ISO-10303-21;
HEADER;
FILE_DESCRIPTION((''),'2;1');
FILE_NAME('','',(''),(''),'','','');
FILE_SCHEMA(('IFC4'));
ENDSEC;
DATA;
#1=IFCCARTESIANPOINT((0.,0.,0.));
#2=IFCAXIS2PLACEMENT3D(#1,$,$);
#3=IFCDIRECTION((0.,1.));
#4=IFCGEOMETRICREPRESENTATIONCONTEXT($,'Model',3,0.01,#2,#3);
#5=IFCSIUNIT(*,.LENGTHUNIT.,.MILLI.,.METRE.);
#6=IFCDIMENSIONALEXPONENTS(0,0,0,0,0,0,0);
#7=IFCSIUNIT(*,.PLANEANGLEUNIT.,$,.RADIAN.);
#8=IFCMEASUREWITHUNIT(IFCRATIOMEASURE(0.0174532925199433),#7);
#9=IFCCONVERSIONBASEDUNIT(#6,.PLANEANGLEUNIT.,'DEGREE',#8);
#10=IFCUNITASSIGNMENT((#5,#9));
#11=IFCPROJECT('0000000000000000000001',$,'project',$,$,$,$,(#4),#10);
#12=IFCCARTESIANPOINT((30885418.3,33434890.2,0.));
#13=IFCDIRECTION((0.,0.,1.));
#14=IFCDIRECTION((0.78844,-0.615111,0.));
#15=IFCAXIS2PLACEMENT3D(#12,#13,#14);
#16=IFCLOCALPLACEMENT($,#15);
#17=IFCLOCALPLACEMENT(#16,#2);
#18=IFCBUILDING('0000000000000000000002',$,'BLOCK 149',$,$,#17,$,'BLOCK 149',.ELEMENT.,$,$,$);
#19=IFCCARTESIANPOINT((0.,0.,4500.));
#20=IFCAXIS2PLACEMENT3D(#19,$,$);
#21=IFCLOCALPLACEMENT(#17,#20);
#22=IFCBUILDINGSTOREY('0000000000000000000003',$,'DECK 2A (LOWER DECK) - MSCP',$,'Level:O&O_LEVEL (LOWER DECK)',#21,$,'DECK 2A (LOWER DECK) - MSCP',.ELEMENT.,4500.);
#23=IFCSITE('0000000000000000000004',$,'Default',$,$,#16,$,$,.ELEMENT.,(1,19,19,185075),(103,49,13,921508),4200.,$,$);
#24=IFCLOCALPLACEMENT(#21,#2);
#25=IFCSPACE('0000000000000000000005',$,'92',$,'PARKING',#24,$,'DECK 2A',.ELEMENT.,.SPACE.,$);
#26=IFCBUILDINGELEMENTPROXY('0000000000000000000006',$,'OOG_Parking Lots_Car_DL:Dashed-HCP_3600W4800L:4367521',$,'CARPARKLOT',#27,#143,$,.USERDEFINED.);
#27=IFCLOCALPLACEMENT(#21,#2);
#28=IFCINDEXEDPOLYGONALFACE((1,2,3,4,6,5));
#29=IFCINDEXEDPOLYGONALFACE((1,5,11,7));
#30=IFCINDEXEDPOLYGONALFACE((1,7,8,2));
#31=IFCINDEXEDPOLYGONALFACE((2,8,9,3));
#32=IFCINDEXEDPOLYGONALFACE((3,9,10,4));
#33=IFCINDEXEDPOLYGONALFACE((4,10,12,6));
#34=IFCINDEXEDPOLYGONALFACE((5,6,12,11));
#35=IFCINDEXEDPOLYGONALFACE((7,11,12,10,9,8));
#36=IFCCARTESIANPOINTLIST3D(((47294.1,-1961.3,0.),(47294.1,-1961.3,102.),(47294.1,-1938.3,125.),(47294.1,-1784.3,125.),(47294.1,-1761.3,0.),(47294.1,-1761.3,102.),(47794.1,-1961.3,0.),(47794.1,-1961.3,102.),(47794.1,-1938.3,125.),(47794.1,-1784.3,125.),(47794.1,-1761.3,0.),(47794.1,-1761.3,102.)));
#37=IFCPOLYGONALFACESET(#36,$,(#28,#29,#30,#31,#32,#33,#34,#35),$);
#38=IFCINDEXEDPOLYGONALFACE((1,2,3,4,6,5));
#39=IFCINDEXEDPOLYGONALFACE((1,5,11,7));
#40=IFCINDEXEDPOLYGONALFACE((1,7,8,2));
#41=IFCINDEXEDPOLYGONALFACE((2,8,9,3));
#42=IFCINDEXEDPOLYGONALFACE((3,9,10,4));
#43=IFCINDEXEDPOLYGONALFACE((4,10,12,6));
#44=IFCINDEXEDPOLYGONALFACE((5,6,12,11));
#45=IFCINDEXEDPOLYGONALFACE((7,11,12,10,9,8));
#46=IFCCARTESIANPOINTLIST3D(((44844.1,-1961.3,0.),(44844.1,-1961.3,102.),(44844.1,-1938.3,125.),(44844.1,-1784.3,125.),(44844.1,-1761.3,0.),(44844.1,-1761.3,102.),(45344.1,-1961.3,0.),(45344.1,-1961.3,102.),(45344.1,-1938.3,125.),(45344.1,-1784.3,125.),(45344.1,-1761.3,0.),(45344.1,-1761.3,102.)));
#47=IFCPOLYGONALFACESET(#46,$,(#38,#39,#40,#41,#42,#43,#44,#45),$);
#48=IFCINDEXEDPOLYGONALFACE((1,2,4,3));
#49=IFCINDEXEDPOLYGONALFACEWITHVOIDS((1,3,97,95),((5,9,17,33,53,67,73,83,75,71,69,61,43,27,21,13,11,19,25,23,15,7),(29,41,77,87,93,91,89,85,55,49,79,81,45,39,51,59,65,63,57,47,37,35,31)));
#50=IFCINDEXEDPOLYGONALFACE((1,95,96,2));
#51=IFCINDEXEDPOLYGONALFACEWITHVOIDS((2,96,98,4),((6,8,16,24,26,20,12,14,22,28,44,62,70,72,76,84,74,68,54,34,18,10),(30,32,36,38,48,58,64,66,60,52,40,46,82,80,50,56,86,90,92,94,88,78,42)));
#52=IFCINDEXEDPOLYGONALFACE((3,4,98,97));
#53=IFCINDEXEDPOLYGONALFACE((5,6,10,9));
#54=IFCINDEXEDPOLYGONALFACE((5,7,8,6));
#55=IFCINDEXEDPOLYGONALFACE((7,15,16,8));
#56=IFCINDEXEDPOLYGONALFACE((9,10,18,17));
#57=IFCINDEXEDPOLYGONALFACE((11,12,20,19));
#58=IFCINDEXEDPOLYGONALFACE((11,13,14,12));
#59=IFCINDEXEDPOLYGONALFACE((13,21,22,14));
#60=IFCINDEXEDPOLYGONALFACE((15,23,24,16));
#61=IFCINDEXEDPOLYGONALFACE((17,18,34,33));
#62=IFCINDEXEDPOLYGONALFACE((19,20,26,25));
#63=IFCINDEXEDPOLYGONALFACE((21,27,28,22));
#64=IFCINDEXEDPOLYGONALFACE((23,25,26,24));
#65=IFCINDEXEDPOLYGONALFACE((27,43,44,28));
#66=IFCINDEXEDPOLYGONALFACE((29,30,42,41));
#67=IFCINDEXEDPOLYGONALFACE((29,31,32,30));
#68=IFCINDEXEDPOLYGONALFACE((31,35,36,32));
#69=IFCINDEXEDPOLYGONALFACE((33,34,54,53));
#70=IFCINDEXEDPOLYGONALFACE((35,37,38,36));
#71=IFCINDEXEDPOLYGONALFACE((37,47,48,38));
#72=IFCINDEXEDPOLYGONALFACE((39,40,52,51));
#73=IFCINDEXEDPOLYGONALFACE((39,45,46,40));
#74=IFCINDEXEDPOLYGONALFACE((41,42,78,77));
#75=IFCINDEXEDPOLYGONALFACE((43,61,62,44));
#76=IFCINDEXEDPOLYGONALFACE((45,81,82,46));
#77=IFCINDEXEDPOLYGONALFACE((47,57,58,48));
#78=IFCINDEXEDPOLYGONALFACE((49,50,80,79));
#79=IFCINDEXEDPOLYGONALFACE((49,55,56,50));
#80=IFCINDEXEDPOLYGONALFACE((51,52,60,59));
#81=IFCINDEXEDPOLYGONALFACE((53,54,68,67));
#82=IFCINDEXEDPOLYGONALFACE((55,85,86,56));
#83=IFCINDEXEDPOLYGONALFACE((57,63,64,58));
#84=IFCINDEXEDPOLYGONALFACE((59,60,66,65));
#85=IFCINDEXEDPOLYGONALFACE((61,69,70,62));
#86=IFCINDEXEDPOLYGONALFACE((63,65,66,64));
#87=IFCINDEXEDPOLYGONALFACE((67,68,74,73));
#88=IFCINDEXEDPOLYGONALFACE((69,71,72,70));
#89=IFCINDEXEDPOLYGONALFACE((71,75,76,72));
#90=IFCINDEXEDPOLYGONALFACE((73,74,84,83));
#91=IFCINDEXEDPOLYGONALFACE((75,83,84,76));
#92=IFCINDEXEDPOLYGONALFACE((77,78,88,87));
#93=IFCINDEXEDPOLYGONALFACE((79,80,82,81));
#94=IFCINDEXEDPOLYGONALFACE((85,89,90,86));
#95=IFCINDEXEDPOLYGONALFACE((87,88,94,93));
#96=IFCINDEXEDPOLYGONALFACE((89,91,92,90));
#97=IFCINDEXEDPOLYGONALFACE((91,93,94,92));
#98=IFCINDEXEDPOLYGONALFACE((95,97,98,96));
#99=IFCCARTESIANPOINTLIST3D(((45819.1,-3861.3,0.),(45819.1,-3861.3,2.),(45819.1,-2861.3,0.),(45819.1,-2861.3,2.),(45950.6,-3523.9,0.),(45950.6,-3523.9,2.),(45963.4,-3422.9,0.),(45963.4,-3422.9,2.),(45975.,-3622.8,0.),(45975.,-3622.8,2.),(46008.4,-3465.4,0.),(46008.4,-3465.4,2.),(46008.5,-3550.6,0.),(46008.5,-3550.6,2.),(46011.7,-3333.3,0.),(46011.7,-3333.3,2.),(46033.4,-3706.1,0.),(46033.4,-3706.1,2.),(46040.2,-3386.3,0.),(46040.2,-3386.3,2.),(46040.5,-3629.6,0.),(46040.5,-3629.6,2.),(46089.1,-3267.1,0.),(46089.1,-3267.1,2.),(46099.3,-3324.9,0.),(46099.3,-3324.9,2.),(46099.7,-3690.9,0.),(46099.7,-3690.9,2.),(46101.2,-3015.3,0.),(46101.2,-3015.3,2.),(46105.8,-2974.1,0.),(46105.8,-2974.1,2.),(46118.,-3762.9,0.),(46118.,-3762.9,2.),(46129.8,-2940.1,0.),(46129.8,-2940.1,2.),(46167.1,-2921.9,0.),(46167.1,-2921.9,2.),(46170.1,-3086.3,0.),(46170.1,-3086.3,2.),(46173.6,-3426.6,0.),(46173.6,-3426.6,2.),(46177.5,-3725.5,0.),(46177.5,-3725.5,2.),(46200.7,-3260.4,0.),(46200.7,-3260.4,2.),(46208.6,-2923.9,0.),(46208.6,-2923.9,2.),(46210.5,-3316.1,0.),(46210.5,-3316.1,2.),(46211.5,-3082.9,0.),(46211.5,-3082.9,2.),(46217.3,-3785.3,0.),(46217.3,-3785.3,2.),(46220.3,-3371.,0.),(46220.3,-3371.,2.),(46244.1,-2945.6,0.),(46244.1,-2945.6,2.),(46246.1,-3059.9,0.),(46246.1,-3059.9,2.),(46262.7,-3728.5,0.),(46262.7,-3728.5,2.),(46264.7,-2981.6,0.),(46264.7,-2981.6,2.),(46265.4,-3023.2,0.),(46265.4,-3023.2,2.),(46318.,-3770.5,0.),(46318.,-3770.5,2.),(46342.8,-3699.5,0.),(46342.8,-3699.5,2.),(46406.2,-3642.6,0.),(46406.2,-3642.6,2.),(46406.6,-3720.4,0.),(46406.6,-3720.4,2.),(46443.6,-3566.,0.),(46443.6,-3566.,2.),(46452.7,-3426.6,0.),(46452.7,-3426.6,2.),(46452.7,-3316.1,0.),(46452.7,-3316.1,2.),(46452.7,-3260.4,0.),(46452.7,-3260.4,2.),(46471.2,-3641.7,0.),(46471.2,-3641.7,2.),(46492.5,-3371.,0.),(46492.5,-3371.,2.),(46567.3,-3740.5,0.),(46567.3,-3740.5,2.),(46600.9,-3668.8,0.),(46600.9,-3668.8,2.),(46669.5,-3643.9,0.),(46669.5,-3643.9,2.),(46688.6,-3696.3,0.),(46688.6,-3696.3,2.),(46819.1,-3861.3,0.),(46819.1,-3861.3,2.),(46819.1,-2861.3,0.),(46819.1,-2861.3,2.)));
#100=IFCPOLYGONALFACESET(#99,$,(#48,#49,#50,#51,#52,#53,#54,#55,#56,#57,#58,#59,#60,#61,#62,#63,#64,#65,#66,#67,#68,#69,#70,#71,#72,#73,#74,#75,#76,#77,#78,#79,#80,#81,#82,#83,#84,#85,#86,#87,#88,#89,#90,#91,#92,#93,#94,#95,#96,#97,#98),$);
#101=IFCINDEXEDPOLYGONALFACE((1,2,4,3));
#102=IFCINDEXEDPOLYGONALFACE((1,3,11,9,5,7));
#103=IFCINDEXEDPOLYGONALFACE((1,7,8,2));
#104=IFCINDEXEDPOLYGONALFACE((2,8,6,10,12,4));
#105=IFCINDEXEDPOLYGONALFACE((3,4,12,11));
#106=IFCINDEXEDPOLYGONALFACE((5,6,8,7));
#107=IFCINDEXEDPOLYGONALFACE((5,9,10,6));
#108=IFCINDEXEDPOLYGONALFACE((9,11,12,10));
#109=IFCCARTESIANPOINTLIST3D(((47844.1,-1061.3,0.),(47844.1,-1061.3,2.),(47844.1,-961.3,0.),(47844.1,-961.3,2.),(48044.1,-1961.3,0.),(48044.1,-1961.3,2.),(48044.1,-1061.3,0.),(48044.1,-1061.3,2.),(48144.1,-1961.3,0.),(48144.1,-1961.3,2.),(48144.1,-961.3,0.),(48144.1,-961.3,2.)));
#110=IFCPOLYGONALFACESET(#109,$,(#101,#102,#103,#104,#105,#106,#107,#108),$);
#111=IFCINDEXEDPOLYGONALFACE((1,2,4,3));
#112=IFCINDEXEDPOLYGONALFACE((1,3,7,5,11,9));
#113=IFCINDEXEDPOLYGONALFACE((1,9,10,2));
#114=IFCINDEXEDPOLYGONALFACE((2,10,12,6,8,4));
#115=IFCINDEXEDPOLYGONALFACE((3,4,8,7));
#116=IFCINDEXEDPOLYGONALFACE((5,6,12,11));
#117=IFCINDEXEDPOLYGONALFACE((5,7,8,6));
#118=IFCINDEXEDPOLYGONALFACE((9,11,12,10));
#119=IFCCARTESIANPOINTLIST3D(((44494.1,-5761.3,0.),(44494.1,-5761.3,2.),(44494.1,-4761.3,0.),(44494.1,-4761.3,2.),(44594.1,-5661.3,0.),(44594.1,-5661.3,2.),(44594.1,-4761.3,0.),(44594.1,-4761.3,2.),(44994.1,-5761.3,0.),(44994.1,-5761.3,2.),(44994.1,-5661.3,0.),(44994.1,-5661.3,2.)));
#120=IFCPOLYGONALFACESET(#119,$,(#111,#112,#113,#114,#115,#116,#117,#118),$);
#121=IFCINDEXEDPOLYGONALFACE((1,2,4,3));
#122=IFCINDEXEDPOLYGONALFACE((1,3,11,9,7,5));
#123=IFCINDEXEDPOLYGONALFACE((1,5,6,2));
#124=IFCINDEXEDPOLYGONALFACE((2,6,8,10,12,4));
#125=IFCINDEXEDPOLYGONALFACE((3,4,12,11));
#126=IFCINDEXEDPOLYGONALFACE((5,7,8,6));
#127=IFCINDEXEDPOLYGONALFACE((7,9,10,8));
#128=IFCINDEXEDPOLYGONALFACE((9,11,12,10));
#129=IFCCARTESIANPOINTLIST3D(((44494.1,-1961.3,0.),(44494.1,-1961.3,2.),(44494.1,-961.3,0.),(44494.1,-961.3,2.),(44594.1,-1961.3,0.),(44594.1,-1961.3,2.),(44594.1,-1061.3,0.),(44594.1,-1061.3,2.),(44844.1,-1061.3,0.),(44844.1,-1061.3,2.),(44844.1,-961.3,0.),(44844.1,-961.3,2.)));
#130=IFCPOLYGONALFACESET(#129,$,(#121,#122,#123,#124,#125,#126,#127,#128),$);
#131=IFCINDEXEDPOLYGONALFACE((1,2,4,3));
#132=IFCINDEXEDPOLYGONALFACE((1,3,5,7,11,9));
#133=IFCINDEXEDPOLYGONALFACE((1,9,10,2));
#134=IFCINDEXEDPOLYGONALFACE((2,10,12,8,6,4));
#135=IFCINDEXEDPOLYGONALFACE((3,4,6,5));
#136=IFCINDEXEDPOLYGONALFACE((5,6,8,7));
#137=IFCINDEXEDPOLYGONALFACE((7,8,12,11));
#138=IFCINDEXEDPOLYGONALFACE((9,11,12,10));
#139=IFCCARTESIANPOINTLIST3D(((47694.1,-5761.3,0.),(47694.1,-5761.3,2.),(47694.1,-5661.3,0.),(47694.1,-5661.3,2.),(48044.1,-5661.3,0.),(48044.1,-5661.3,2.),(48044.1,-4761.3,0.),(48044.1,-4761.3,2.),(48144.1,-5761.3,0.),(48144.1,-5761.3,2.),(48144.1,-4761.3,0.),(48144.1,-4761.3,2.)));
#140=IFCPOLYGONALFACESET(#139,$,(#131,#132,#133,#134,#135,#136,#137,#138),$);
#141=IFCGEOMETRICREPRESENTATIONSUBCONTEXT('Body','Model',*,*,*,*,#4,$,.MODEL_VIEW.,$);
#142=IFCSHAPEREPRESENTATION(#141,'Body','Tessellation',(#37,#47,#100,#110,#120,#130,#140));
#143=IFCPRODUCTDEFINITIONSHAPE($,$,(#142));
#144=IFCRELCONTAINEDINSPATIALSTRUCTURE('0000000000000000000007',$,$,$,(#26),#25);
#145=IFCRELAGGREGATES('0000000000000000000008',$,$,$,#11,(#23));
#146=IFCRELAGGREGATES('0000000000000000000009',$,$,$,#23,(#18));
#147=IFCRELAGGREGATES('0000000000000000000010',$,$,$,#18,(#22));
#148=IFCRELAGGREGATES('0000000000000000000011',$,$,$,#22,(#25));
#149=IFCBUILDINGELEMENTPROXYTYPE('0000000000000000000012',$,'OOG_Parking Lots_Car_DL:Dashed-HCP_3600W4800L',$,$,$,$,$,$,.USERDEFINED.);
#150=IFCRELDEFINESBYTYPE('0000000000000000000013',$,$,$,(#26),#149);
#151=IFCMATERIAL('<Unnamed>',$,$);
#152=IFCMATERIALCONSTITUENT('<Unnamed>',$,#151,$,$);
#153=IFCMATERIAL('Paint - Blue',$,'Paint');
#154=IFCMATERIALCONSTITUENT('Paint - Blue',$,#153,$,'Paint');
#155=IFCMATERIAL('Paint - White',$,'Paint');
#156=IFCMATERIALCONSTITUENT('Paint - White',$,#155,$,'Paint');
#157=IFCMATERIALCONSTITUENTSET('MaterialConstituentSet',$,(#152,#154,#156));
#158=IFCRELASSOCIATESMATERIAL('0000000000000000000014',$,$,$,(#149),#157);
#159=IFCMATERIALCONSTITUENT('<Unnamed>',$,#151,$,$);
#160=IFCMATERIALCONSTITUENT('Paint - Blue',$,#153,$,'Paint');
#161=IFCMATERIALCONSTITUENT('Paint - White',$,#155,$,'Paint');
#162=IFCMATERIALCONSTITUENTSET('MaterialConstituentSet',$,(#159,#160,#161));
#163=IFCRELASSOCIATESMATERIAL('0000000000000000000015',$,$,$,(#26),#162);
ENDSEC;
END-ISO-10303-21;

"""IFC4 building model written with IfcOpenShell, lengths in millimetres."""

from ifc_helpers import new_model, entity, si_unit, converted_unit, direction, frame, origin, place, context, subcontext, project, spatial, indexed_curve, outline, extrude, source, transform, mapped, material, constituent, constituent_set, type_object, type_shapes, element, save


model = new_model("IFC4")

# Units and contexts
model_context = context("Model", 3, precision=0.01, world=origin(), true_north=direction((0.0, 1.0)))
body_context = subcontext(model_context, "Body", "Model", "MODEL_VIEW")
ifc_project = project(units=[si_unit("LENGTHUNIT", "METRE", prefix="MILLI"), converted_unit("PLANEANGLEUNIT", "DEGREE", entity("IfcRatioMeasure", 0.0174532925199433), si_unit("PLANEANGLEUNIT", "RADIAN"), dimensions=[0, 0, 0, 0, 0, 0, 0])], contexts=[model_context])

# Site, building, storey
site_placement = place(None, frame((30885418.3, 33434890.2, 0.0), z_axis=(0.0, 0.0, 1.0), x_axis=(0.78844, -0.615111, 0.0)))
site = spatial("IfcSite", under=ifc_project, at=site_placement, Name="Default", CompositionType="ELEMENT", RefLatitude=(1, 19, 19, 185075), RefLongitude=(103, 49, 13, 921508), RefElevation=4200.0)
building_placement = place(site_placement, origin())
building = spatial("IfcBuilding", under=site, at=building_placement, Name="BLOCK 149", LongName="BLOCK 149", CompositionType="ELEMENT")
storey_placement = place(building_placement, frame((0.0, 0.0, 4500.0)))
storey = spatial("IfcBuildingStorey", under=building, at=storey_placement, Name="DECK 2A (LOWER DECK) - MSCP", ObjectType="Level:O&O_LEVEL (LOWER DECK)", LongName="DECK 2A (LOWER DECK) - MSCP", CompositionType="ELEMENT", Elevation=4500.0)

# Shared definitions
ifc_material_1 = material(Name="<Unnamed>")

# Shared definitions
space_placement = place(storey_placement, origin())
space = spatial("IfcSpace", under=storey, at=space_placement, Name="92", ObjectType="PARKING", LongName="DECK 2A", CompositionType="ELEMENT", PredefinedType="SPACE")

# Building element proxy
ifc_material_2 = material(Name="Paint - White", Category="Paint")
ifc_material_3 = material(Name="Paint - Blue", Category="Paint")
ifc_constituent_1 = constituent(ifc_material_1, Name="<Unnamed>")
ifc_constituent_2 = constituent(ifc_material_3, Name="Paint - Blue", Category="Paint")
ifc_constituent_3 = constituent(ifc_material_2, Name="Paint - White", Category="Paint")
ifc_constituent_set_1 = constituent_set(constituents=[ifc_constituent_1, ifc_constituent_2, ifc_constituent_3], Name="MaterialConstituentSet")
ifc_constituent_4 = constituent(ifc_material_1, Name="<Unnamed>")
ifc_constituent_5 = constituent(ifc_material_3, Name="Paint - Blue", Category="Paint")
ifc_constituent_6 = constituent(ifc_material_2, Name="Paint - White", Category="Paint")
ifc_constituent_set_2 = constituent_set(constituents=[ifc_constituent_4, ifc_constituent_5, ifc_constituent_6], Name="MaterialConstituentSet")
building_element_proxy_type_1 = type_object("IfcBuildingElementProxyType", Name="OOG_Parking Lots_Car_DL:Dashed-HCP_3600W4800L", PredefinedType="USERDEFINED", material=ifc_constituent_set_2)
shared_shape_1 = source(origin(), body_context, "Body", "SweptSolid", [
    extrude(outline(indexed_curve([(-100.0, -75.7), (100.0, -75.7), (100.0, 26.3), (77.0, 49.3), (-77.0, 49.3), (-100.0, 26.3), (-100.0, -75.7)], self_intersect=False)), frame((2750.0, -850.0, 75.7), z_axis=(1.0, 0.0, 0.0), x_axis=(0.0, 1.0, 0.0)), (0.0, 0.0, 1.0), 500.0),
    extrude(outline(indexed_curve([(-100.0, -75.7), (100.0, -75.7), (100.0, 26.3), (77.0, 49.3), (-77.0, 49.3), (-100.0, 26.3), (-100.0, -75.7)], self_intersect=False)), frame((300.0, -850.0, 75.7), z_axis=(1.0, 0.0, 0.0), x_axis=(0.0, 1.0, 0.0)), (0.0, 0.0, 1.0), 500.0),
    extrude(outline(indexed_curve([(-500.0, -500.0), (500.0, -500.0), (500.0, 500.0), (-500.0, 500.0), (-500.0, -500.0)], self_intersect=False), holes=[indexed_curve([(149.0, -274.9), (118.4, -100.9), (-133.6, -100.9), (-133.6, -45.2), (108.6, -45.2), (98.8, 9.7), (-173.4, 9.7), (-281.8, 307.5), (-350.4, 282.6), (-369.5, 335.1), (-248.2, 379.2), (-133.6, 65.3), (145.5, 65.3), (218.0, -346.0), (213.3, -387.2), (189.3, -421.2), (152.0, -439.4), (110.5, -437.4), (75.1, -415.7), (54.4, -379.7), (53.7, -338.1), (73.0, -301.3), (107.6, -278.4), (149.0, -274.9)], self_intersect=False), indexed_curve([(-124.5, 204.7), (-152.1, 280.4), (-87.5, 359.1), (1.1, 409.2), (101.8, 424.0), (201.1, 401.6), (285.7, 344.9), (344.1, 261.5), (368.6, 162.6), (355.8, 61.6), (307.4, -28.0), (230.0, -94.2), (219.8, -36.4), (278.9, 25.0), (310.7, 104.1), (310.6, 189.3), (278.7, 268.3), (219.4, 329.6), (141.6, 364.2), (56.5, 367.3), (-23.6, 338.2), (-87.0, 281.3), (-124.5, 204.7)], self_intersect=False)]), frame((1775.0, -2350.0, 0.0), z_axis=(0.0, 0.0, 1.0), x_axis=(-1.0, 0.0, 0.0)), (0.0, 0.0, 1.0), 2.0),
    extrude(outline(indexed_curve([(-633.3, -133.3), (366.7, -133.3), (366.7, 166.7), (266.7, 166.7), (266.7, -33.3), (-633.3, -33.3), (-633.3, -133.3)], self_intersect=False)), frame((3466.7, -316.7, 0.0), z_axis=(0.0, 0.0, 1.0), x_axis=(0.0, 1.0, 0.0)), (0.0, 0.0, 1.0), 2.0),
    extrude(outline(indexed_curve([(-633.3, -200.0), (366.7, -200.0), (366.7, 300.0), (266.7, 300.0), (266.7, -100.0), (-633.3, -100.0), (-633.3, -200.0)], self_intersect=False)), frame((150.0, -4383.3, 0.0), z_axis=(0.0, 0.0, 1.0), x_axis=(0.0, -1.0, 0.0)), (0.0, 0.0, 1.0), 2.0),
    extrude(outline(indexed_curve([(-200.0, -366.7), (150.0, -366.7), (150.0, 633.3), (50.0, 633.3), (50.0, -266.7), (-200.0, -266.7), (-200.0, -366.7)], self_intersect=False)), frame((100.0, -316.7, 0.0), z_axis=(0.0, 0.0, 1.0), x_axis=(-1.0, 0.0, 0.0)), (0.0, 0.0, 1.0), 2.0),
    extrude(outline(indexed_curve([(-266.7, -366.7), (183.3, -366.7), (183.3, 633.3), (83.3, 633.3), (83.3, -266.7), (-266.7, -266.7), (-266.7, -366.7)], self_intersect=False)), frame((3416.7, -4383.3, 0.0)), (0.0, 0.0, 1.0), 2.0),
])
type_shapes(building_element_proxy_type_1, [shared_shape_1])
proxy_1_placement = place(space_placement, frame((44544.1, -1011.3, 0.0)))
element("IfcBuildingElementProxy", 1, at=proxy_1_placement, inside=space, type_object=building_element_proxy_type_1, material=ifc_constituent_set_1, Name="OOG_Parking Lots_Car_DL:Dashed-HCP_3600W4800L:4367521", ObjectType="CARPARKLOT", PredefinedType="USERDEFINED", context=body_context, shape_type="MappedRepresentation", body=[
    mapped(shared_shape_1, transform((0.0, 0.0, 0.0), scale=1.0)),
])

save(model, "model.ifc")
